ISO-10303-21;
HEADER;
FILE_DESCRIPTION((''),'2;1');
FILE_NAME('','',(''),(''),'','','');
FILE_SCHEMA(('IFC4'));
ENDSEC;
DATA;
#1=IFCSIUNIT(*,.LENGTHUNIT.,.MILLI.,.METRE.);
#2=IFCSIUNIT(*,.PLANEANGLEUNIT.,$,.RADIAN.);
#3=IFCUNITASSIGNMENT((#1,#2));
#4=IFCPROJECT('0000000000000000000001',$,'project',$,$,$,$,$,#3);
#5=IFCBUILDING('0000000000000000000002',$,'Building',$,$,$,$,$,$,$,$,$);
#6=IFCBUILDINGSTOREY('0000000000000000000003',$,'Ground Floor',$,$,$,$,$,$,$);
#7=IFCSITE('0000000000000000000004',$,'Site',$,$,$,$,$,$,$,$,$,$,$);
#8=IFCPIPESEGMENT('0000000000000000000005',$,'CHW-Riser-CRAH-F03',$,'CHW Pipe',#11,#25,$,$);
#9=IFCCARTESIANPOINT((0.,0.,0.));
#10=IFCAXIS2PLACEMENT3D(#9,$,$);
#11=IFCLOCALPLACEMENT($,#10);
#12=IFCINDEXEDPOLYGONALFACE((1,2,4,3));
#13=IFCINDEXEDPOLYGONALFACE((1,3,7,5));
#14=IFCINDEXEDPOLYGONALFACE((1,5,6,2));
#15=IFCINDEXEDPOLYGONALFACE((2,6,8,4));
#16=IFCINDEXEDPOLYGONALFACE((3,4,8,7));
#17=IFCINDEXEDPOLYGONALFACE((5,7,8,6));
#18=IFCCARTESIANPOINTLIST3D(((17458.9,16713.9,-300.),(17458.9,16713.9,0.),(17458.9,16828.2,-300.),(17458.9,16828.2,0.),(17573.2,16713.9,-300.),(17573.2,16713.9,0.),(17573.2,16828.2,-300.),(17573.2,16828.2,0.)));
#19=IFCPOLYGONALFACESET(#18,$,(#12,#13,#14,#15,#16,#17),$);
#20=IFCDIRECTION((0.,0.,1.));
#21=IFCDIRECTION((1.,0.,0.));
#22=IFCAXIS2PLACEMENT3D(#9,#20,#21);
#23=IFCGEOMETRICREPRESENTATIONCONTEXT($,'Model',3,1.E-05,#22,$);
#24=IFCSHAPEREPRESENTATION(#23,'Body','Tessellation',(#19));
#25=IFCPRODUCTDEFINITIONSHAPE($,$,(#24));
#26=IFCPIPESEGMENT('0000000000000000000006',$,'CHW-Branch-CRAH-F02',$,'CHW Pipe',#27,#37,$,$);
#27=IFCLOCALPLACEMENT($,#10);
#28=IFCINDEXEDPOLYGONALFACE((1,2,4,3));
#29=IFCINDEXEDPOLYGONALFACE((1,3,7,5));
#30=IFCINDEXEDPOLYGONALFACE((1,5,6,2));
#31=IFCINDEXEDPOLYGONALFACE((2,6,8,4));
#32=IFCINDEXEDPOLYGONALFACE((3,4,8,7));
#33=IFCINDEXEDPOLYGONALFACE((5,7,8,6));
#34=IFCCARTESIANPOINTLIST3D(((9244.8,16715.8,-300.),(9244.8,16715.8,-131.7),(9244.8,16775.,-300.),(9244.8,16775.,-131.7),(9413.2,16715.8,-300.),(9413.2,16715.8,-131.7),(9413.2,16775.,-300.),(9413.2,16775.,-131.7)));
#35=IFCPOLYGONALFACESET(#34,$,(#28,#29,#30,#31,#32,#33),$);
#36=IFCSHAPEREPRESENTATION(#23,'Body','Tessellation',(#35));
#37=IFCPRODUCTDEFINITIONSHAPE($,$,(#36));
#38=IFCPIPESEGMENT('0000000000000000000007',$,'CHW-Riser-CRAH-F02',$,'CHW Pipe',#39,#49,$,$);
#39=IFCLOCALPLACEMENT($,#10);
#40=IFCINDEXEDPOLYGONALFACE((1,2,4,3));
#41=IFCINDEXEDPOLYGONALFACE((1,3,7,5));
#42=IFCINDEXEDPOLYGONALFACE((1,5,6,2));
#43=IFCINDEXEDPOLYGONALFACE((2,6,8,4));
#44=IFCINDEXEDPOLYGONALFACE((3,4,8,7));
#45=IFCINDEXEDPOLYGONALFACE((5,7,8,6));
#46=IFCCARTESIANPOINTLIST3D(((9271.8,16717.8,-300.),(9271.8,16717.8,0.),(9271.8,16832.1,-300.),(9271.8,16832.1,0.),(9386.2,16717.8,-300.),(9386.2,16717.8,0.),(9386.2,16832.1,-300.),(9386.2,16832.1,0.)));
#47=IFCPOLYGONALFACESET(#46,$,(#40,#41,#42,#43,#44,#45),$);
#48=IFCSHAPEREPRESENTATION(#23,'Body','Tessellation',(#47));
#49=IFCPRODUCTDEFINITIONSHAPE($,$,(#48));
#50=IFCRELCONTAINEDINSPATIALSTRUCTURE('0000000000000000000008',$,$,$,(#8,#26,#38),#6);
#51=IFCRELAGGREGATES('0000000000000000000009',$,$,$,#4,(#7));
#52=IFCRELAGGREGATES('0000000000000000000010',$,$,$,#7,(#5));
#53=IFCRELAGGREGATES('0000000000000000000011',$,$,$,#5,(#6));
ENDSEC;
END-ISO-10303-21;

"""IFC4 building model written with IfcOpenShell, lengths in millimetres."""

from ifc_helpers import new_model, si_unit, frame, origin_with_axes, place, context, project, spatial, rectangle, extrude, element, save


model = new_model("IFC4")

# Units and contexts
model_context = context("Model", 3, precision=1e-05, world=origin_with_axes())
ifc_project = project(units=[si_unit("LENGTHUNIT", "METRE", prefix="MILLI"), si_unit("PLANEANGLEUNIT", "RADIAN")])

# Site, building, storey
site = spatial("IfcSite", under=ifc_project, Name="Site")
building = spatial("IfcBuilding", under=site, Name="Building")
storey = spatial("IfcBuildingStorey", under=building, Name="Ground Floor")

# Pipe segments
pipe_segment_1_placement = place(None, origin_with_axes())
element("IfcPipeSegment", 1, at=pipe_segment_1_placement, inside=storey, Name="CHW-Riser-CRAH-F03", ObjectType="CHW Pipe", context=model_context, shape_type="SweptSolid", body=[
    extrude(rectangle(XDim=114.3, YDim=114.3), frame((17516.0, 16771.0, -300.0), z_axis=(0.0, 0.0, 1.0), x_axis=(1.0, 0.0, 0.0)), (0.0, 0.0, 1.0), 300.0),
])
pipe_segment_2_placement = place(None, origin_with_axes())
element("IfcPipeSegment", 2, at=pipe_segment_2_placement, inside=storey, Name="CHW-Branch-CRAH-F02", ObjectType="CHW Pipe", context=model_context, shape_type="SweptSolid", body=[
    extrude(rectangle(XDim=168.3, YDim=59.2), frame((9329.0, 16745.4, -300.0), z_axis=(0.0, 0.0, 1.0), x_axis=(1.0, 0.0, 0.0)), (0.0, 0.0, 1.0), 168.3),
])
pipe_segment_3_placement = place(None, origin_with_axes())
element("IfcPipeSegment", 3, at=pipe_segment_3_placement, inside=storey, Name="CHW-Riser-CRAH-F02", ObjectType="CHW Pipe", context=model_context, shape_type="SweptSolid", body=[
    extrude(rectangle(XDim=114.3, YDim=114.3), frame((9329.0, 16775.0, -300.0), z_axis=(0.0, 0.0, 1.0), x_axis=(1.0, 0.0, 0.0)), (0.0, 0.0, 1.0), 300.0),
])

save(model, "model.ifc")
